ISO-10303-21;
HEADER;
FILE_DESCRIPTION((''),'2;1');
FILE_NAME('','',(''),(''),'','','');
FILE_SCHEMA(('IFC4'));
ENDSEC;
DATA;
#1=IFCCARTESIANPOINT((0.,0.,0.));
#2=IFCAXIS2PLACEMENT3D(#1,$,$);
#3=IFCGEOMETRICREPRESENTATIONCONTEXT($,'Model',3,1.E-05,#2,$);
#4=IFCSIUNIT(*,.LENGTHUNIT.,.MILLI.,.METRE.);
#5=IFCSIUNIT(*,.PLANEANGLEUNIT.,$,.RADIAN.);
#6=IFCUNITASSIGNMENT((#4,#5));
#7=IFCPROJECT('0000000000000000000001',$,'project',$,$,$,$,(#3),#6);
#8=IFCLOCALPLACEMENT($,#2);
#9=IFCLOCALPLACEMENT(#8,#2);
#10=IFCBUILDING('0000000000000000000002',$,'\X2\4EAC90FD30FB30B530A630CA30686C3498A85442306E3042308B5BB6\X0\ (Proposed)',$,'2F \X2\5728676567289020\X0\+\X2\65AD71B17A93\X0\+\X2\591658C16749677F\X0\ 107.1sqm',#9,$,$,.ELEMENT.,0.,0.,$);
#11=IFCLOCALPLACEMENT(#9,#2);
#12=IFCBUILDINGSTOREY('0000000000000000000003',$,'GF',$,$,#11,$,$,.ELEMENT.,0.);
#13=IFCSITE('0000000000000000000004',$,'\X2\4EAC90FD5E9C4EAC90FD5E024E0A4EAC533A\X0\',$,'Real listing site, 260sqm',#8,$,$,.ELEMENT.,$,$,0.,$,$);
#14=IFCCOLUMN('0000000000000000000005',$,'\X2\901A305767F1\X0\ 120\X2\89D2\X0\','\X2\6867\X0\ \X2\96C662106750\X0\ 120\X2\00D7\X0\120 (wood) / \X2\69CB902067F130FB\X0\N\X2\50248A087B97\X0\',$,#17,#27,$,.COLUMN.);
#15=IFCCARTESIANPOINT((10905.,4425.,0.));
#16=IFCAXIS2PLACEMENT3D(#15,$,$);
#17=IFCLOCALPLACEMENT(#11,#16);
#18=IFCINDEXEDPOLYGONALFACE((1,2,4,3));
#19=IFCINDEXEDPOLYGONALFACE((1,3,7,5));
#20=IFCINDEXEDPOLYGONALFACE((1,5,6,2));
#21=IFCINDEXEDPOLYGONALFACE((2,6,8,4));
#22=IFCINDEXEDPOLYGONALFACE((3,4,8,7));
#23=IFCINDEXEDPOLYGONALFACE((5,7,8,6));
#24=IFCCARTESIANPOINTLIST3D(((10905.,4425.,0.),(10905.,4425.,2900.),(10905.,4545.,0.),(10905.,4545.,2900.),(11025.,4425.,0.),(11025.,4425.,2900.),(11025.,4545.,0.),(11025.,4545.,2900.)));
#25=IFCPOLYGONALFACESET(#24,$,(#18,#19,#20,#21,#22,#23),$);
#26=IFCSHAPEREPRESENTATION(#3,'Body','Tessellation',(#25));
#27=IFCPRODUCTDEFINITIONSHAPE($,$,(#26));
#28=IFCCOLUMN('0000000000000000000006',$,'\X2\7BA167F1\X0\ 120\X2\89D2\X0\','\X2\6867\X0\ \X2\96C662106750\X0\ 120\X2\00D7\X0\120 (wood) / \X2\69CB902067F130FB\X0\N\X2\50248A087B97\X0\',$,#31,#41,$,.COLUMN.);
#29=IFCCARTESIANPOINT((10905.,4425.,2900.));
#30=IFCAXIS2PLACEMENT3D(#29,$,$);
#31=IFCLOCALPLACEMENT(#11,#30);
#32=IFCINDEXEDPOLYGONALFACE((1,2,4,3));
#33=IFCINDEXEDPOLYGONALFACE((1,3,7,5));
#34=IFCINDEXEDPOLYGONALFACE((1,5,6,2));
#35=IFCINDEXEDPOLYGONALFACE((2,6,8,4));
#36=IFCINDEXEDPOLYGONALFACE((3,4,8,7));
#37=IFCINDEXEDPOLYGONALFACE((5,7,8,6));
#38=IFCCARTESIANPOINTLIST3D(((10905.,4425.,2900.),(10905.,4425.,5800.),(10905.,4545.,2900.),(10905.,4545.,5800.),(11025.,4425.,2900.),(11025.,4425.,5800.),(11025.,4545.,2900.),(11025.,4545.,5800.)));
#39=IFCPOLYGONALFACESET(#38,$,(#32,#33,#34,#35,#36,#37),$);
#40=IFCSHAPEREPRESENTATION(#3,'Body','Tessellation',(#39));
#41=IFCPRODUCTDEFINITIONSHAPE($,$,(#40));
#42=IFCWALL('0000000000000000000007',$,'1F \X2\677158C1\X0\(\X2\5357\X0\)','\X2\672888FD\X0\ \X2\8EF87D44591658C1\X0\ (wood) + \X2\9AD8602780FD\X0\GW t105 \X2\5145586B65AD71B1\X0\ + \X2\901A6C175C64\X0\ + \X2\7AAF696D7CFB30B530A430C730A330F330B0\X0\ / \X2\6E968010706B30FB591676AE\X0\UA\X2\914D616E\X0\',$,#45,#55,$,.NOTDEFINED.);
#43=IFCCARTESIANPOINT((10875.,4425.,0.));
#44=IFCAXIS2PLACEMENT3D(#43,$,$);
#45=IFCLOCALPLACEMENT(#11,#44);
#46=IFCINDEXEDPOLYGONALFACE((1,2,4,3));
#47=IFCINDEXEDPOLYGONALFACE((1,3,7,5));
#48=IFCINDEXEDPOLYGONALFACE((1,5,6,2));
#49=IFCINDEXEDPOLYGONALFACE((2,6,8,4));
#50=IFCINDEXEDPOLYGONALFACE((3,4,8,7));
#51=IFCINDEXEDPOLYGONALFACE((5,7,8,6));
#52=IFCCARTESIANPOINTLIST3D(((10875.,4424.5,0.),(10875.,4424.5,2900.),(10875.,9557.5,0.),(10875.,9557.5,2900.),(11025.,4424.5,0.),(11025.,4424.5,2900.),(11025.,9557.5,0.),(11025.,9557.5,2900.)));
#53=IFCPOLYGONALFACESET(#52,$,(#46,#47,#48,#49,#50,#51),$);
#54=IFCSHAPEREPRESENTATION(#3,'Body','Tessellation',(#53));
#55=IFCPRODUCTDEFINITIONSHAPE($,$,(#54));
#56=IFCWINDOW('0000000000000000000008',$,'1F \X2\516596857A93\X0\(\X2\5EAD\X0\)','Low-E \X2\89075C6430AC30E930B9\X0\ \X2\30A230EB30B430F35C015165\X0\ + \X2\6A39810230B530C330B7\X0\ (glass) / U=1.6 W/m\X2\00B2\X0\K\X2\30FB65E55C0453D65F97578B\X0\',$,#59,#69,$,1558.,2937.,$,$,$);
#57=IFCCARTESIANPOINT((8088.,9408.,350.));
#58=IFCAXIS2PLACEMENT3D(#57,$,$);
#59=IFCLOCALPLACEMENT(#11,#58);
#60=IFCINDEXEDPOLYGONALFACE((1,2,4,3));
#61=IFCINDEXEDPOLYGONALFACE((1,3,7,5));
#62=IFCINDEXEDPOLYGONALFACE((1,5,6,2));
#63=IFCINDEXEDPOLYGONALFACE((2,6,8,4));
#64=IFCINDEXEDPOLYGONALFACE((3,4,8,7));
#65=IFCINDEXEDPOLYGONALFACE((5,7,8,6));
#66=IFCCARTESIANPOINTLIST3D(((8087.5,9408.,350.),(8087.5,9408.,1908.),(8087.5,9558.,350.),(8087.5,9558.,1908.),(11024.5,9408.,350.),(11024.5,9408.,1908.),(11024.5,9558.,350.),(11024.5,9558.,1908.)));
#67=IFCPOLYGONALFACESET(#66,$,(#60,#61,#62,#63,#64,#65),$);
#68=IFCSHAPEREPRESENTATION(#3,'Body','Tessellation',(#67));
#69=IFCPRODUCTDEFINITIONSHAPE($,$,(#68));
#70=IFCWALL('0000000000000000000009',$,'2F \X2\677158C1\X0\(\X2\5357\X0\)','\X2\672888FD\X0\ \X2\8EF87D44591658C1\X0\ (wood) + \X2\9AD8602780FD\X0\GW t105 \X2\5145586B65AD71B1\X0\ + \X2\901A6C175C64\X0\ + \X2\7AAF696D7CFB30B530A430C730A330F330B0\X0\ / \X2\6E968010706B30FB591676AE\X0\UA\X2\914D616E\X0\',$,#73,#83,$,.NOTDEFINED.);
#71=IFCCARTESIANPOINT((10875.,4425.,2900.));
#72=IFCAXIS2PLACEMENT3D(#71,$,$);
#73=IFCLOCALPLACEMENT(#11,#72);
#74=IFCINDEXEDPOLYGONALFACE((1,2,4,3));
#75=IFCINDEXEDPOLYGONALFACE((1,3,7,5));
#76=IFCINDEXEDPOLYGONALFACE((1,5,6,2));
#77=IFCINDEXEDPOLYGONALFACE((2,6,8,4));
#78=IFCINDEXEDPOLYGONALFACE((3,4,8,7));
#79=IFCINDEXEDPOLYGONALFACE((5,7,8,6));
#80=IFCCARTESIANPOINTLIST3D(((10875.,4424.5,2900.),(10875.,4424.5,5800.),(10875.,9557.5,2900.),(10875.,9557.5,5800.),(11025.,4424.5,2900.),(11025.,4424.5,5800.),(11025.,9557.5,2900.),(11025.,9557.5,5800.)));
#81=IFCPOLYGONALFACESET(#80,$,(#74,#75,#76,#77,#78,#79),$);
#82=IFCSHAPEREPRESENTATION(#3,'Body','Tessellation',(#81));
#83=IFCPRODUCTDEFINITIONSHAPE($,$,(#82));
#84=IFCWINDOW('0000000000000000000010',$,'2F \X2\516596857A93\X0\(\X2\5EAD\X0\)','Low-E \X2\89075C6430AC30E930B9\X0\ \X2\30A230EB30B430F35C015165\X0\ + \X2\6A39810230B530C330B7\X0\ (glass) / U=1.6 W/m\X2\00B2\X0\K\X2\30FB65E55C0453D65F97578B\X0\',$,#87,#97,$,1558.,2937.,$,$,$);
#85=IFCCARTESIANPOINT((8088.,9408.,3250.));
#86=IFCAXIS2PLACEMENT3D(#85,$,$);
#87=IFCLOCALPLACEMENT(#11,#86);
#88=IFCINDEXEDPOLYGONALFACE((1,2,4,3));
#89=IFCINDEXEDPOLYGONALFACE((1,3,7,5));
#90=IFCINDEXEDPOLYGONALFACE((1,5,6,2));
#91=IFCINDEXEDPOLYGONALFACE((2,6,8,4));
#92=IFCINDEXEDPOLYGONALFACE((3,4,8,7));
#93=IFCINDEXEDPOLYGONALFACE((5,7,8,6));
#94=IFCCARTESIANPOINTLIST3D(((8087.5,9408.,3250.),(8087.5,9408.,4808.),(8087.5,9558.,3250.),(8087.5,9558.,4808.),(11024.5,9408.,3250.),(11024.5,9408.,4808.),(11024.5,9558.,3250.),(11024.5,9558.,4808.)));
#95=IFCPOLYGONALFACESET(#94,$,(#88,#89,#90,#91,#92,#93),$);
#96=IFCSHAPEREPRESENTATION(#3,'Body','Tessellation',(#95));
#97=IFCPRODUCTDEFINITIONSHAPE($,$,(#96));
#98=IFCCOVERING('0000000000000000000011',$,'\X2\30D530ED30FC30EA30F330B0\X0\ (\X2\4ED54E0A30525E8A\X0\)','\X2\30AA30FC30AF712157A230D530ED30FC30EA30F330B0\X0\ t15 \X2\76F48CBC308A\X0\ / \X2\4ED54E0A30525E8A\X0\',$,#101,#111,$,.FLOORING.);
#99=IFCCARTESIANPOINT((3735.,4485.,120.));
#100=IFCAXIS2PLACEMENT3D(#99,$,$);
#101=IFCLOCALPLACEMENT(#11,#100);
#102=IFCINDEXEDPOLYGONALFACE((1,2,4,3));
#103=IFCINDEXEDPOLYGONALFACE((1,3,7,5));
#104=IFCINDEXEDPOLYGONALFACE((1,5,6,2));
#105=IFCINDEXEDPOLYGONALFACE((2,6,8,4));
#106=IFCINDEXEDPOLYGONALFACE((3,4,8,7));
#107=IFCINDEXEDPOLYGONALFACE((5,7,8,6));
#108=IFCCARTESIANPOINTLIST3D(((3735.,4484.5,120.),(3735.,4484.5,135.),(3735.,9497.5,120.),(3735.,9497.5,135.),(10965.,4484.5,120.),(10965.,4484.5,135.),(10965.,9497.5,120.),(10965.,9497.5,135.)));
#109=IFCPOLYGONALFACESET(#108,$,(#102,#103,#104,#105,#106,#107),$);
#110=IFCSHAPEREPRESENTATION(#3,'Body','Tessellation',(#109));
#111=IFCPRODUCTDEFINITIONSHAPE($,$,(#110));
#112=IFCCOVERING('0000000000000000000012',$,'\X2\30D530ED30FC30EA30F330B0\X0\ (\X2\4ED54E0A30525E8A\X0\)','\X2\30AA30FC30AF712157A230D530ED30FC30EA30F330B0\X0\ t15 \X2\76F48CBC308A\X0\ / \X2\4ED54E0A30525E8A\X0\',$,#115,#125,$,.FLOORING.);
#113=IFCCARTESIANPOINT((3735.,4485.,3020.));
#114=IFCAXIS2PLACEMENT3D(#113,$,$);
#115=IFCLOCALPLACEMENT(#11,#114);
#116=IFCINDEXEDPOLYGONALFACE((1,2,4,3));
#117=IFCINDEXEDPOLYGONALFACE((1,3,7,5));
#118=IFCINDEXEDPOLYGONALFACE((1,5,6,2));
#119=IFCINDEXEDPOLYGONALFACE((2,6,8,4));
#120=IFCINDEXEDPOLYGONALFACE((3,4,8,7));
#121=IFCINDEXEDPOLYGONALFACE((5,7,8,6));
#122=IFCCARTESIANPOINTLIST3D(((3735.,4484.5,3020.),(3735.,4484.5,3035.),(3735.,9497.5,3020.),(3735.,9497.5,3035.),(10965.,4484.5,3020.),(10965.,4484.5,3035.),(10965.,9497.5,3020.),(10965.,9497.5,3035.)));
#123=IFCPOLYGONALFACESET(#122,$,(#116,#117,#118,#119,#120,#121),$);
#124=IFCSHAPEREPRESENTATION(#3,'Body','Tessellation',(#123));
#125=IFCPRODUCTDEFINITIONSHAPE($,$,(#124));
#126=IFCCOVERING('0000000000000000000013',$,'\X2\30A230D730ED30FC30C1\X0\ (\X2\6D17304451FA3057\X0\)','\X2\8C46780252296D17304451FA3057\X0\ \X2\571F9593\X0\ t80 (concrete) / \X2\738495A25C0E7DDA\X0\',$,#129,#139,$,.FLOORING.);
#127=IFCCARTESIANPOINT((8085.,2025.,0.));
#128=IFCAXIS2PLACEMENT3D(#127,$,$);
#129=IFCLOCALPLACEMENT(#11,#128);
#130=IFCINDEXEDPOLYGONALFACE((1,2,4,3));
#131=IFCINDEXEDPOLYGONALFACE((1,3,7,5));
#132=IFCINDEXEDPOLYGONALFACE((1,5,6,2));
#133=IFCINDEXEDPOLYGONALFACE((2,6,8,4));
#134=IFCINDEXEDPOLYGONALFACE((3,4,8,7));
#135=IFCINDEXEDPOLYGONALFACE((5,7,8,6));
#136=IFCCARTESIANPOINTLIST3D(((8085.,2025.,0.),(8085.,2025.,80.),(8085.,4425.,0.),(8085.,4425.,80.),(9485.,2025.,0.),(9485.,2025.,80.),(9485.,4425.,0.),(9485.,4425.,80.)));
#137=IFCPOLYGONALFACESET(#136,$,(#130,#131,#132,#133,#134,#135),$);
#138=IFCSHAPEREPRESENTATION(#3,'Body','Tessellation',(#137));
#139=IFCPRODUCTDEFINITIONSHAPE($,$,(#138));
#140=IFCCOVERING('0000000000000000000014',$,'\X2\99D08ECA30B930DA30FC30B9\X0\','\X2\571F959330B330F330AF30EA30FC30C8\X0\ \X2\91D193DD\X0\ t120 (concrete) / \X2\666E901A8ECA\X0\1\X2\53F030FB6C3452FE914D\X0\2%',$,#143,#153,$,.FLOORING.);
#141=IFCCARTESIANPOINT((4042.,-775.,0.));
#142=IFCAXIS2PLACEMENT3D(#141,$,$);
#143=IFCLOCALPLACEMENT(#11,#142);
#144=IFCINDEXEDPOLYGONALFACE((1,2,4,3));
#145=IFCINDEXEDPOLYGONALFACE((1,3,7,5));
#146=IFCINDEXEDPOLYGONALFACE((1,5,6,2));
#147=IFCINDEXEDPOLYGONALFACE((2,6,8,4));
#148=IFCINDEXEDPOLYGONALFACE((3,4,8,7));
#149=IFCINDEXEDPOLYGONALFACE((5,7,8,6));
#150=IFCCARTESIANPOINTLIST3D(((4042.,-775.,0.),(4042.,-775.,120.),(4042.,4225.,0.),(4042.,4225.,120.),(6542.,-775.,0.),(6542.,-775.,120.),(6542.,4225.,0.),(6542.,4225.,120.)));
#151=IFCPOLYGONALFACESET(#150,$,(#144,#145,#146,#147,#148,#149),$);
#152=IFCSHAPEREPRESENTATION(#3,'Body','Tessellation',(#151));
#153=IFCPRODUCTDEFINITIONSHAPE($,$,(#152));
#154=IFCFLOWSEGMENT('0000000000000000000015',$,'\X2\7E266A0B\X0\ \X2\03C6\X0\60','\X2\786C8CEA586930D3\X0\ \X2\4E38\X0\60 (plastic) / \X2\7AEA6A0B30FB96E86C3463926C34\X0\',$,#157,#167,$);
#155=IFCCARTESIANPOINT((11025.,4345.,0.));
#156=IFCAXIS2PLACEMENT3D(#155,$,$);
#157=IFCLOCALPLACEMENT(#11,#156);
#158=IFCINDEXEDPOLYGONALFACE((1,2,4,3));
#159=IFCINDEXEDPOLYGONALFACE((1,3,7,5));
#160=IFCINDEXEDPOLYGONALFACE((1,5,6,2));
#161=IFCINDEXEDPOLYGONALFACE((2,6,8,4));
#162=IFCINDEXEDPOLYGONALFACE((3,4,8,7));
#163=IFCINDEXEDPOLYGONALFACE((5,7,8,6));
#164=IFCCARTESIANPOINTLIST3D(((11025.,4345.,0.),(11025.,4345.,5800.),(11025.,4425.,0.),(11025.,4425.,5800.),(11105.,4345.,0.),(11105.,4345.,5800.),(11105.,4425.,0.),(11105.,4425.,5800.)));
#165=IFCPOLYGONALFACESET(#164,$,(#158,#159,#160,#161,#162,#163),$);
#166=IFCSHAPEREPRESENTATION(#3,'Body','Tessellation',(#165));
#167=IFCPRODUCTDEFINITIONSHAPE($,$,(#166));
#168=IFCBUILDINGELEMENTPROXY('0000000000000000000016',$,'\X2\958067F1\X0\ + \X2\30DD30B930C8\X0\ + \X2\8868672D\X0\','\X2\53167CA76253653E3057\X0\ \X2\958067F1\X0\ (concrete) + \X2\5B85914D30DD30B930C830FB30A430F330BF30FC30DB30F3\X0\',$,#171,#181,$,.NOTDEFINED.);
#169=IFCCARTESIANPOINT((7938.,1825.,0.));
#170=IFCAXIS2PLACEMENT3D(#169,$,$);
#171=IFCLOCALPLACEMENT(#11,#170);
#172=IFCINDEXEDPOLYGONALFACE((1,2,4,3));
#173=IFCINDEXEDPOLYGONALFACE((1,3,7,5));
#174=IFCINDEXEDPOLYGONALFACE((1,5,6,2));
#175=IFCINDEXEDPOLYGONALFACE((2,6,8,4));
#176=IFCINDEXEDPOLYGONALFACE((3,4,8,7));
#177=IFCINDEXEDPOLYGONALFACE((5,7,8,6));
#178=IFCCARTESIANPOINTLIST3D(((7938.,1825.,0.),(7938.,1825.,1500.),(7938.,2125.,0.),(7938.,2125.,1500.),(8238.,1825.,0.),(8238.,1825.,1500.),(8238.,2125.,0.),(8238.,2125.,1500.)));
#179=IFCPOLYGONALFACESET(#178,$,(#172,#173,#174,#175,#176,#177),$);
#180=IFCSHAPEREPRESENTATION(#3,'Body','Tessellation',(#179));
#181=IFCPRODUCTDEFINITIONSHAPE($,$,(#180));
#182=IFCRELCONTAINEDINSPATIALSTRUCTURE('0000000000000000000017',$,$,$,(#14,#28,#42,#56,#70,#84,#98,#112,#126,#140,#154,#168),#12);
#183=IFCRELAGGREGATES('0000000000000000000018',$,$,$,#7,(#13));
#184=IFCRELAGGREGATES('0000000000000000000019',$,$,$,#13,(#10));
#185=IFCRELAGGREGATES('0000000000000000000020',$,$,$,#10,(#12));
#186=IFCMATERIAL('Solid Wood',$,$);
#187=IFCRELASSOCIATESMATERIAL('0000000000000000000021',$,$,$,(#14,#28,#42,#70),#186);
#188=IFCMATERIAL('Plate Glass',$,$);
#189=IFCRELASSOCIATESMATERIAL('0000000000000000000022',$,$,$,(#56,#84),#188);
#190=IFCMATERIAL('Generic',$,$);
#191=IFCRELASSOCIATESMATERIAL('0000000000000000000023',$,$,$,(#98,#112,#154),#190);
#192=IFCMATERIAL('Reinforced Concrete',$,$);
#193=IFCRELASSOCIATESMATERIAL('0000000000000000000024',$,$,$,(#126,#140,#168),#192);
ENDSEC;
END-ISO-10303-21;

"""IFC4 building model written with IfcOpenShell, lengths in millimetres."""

from ifc_helpers import new_model, si_unit, frame, frame_2d, origin, place, context, project, spatial, rectangle, extrude, material, element, fill, save


model = new_model("IFC4")

# Units and contexts
model_context = context("Model", 3, precision=1e-05, world=origin())
ifc_project = project(units=[si_unit("LENGTHUNIT", "METRE", prefix="MILLI"), si_unit("PLANEANGLEUNIT", "RADIAN")], contexts=[model_context])

# Site, building, storey
site_placement = place(None, origin())
site = spatial("IfcSite", under=ifc_project, at=site_placement, Name="京都府京都市上京区", ObjectType="Real listing site, 260sqm", CompositionType="ELEMENT", RefElevation=0.0)
building_placement = place(site_placement, origin())
building = spatial("IfcBuilding", under=site, at=building_placement, Name="京都・サウナと水風呂のある家 (Proposed)", ObjectType="2F 在来木造+断熱窓+外壁杉板 107.1sqm", CompositionType="ELEMENT", ElevationOfRefHeight=0.0, ElevationOfTerrain=0.0)
storey_placement = place(building_placement, origin())
storey = spatial("IfcBuildingStorey", under=building, at=storey_placement, Name="GF", CompositionType="ELEMENT", Elevation=0.0)

# Columns
ifc_material_1 = material(Name="Solid Wood")
column_1_placement = place(storey_placement, frame((10905.0, 4425.0, 0.0)))
element("IfcColumn", 1, at=column_1_placement, inside=storey, material=ifc_material_1, Name="通し柱 120角", Description="桧 集成材 120×120 (wood) / 構造柱・N値計算", PredefinedType="COLUMN", context=model_context, shape_type="SweptSolid", body=[
    extrude(rectangle(XDim=120.0, YDim=120.0, at=frame_2d((60.0, 60.0))), frame((10905.0, 4425.0, 0.0)), (0.0, 0.0, 1.0), 2900.0),
])
column_2_placement = place(storey_placement, frame((10905.0, 4425.0, 2900.0)))
element("IfcColumn", 2, at=column_2_placement, inside=storey, material=ifc_material_1, Name="管柱 120角", Description="桧 集成材 120×120 (wood) / 構造柱・N値計算", PredefinedType="COLUMN", context=model_context, shape_type="SweptSolid", body=[
    extrude(rectangle(XDim=120.0, YDim=120.0, at=frame_2d((60.0, 60.0))), frame((10905.0, 4425.0, 2900.0)), (0.0, 0.0, 1.0), 2900.0),
])

# Wall, opening, window
wall_1_placement = place(storey_placement, frame((10875.0, 4425.0, 0.0)))
wall_1 = element("IfcWall", 3, at=wall_1_placement, inside=storey, material=ifc_material_1, Name="1F 東壁(南)", Description="木製 軸組外壁 (wood) + 高性能GW t105 充填断熱 + 通気層 + 窯業系サイディング / 準耐火・外皮UA配慮", PredefinedType="NOTDEFINED", context=model_context, shape_type="SweptSolid", body=[
    extrude(rectangle(XDim=150.0, YDim=5133.0, at=frame_2d((75.0, 2566.0))), frame((10875.0, 4425.0, 0.0)), (0.0, 0.0, 1.0), 2900.0),
])
opening_1_placement = place(storey_placement, frame((8088.0, 9408.0, 350.0)))
opening_1 = element("IfcOpeningElement", 4, at=opening_1_placement, cuts=wall_1, PredefinedType="NOTDEFINED", context=model_context, shape_type="SweptSolid", body=[
    extrude(rectangle(XDim=2937.0, YDim=150.0, at=frame_2d((1468.0, 75.0))), frame((8088.0, 9408.0, 350.0)), (0.0, 0.0, 1.0), 1558.0),
])
ifc_material_2 = material(Name="Plate Glass")
window_1_placement = place(storey_placement, frame((8088.0, 9408.0, 350.0)))
window_1 = element("IfcWindow", 5, at=window_1_placement, inside=storey, material=ifc_material_2, Name="1F 入隅窓(庭)", Description="Low-E 複層ガラス アルゴン封入 + 樹脂サッシ (glass) / U=1.6 W/m²K・日射取得型", OverallHeight=1558.0, OverallWidth=2937.0, context=model_context, shape_type="SweptSolid", body=[
    extrude(rectangle(XDim=2937.0, YDim=150.0, at=frame_2d((1468.0, 75.0))), frame((8088.0, 9408.0, 350.0)), (0.0, 0.0, 1.0), 1558.0),
])
fill(opening_1, window_1)

# Wall, opening, window
wall_2_placement = place(storey_placement, frame((10875.0, 4425.0, 2900.0)))
wall_2 = element("IfcWall", 6, at=wall_2_placement, inside=storey, material=ifc_material_1, Name="2F 東壁(南)", Description="木製 軸組外壁 (wood) + 高性能GW t105 充填断熱 + 通気層 + 窯業系サイディング / 準耐火・外皮UA配慮", PredefinedType="NOTDEFINED", context=model_context, shape_type="SweptSolid", body=[
    extrude(rectangle(XDim=150.0, YDim=5133.0, at=frame_2d((75.0, 2566.0))), frame((10875.0, 4425.0, 2900.0)), (0.0, 0.0, 1.0), 2900.0),
])
opening_2_placement = place(storey_placement, frame((8088.0, 9408.0, 3250.0)))
opening_2 = element("IfcOpeningElement", 7, at=opening_2_placement, cuts=wall_2, PredefinedType="NOTDEFINED", context=model_context, shape_type="SweptSolid", body=[
    extrude(rectangle(XDim=2937.0, YDim=150.0, at=frame_2d((1468.0, 75.0))), frame((8088.0, 9408.0, 3250.0)), (0.0, 0.0, 1.0), 1558.0),
])
window_2_placement = place(storey_placement, frame((8088.0, 9408.0, 3250.0)))
window_2 = element("IfcWindow", 8, at=window_2_placement, inside=storey, material=ifc_material_2, Name="2F 入隅窓(庭)", Description="Low-E 複層ガラス アルゴン封入 + 樹脂サッシ (glass) / U=1.6 W/m²K・日射取得型", OverallHeight=1558.0, OverallWidth=2937.0, context=model_context, shape_type="SweptSolid", body=[
    extrude(rectangle(XDim=2937.0, YDim=150.0, at=frame_2d((1468.0, 75.0))), frame((8088.0, 9408.0, 3250.0)), (0.0, 0.0, 1.0), 1558.0),
])
fill(opening_2, window_2)

# Coverings
ifc_material_3 = material(Name="Generic")
covering_1_placement = place(storey_placement, frame((3735.0, 4485.0, 120.0)))
element("IfcCovering", 9, at=covering_1_placement, inside=storey, material=ifc_material_3, Name="フローリング (仕上げ床)", Description="オーク無垢フローリング t15 直貼り / 仕上げ床", PredefinedType="FLOORING", context=model_context, shape_type="SweptSolid", body=[
    extrude(rectangle(XDim=7230.0, YDim=5013.0, at=frame_2d((3615.0, 2506.0))), frame((3735.0, 4485.0, 120.0)), (0.0, 0.0, 1.0), 15.0),
])
covering_2_placement = place(storey_placement, frame((3735.0, 4485.0, 3020.0)))
element("IfcCovering", 10, at=covering_2_placement, inside=storey, material=ifc_material_3, Name="フローリング (仕上げ床)", Description="オーク無垢フローリング t15 直貼り / 仕上げ床", PredefinedType="FLOORING", context=model_context, shape_type="SweptSolid", body=[
    extrude(rectangle(XDim=7230.0, YDim=5013.0, at=frame_2d((3615.0, 2506.0))), frame((3735.0, 4485.0, 3020.0)), (0.0, 0.0, 1.0), 15.0),
])
ifc_material_4 = material(Name="Reinforced Concrete")
covering_3_placement = place(storey_placement, frame((8085.0, 2025.0, 0.0)))
element("IfcCovering", 11, at=covering_3_placement, inside=storey, material=ifc_material_4, Name="アプローチ (洗い出し)", Description="豆砂利洗い出し 土間 t80 (concrete) / 玄関導線", PredefinedType="FLOORING", context=model_context, shape_type="SweptSolid", body=[
    extrude(rectangle(XDim=1400.0, YDim=2400.0, at=frame_2d((700.0, 1200.0))), frame((8085.0, 2025.0, 0.0)), (0.0, 0.0, 1.0), 80.0),
])
covering_4_placement = place(storey_placement, frame((4042.0, -775.0, 0.0)))
element("IfcCovering", 12, at=covering_4_placement, inside=storey, material=ifc_material_4, Name="駐車スペース", Description="土間コンクリート 金鏝 t120 (concrete) / 普通車1台・水勾配2%", PredefinedType="FLOORING", context=model_context, shape_type="SweptSolid", body=[
    extrude(rectangle(XDim=2500.0, YDim=5000.0, at=frame_2d((1250.0, 2500.0))), frame((4042.0, -775.0, 0.0)), (0.0, 0.0, 1.0), 120.0),
])

# Flow segment
flow_segment_placement = place(storey_placement, frame((11025.0, 4345.0, 0.0)))
element("IfcFlowSegment", 13, at=flow_segment_placement, inside=storey, material=ifc_material_3, Name="縦樋 φ60", Description="硬質塩ビ 丸60 (plastic) / 竪樋・雨水排水", context=model_context, shape_type="SweptSolid", body=[
    extrude(rectangle(XDim=80.0, YDim=80.0, at=frame_2d((40.0, 40.0))), frame((11025.0, 4345.0, 0.0)), (0.0, 0.0, 1.0), 5800.0),
])

# Building element proxy
proxy_placement = place(storey_placement, frame((7938.0, 1825.0, 0.0)))
element("IfcBuildingElementProxy", 14, at=proxy_placement, inside=storey, material=ifc_material_4, Name="門柱 + ポスト + 表札", Description="化粧打放し 門柱 (concrete) + 宅配ポスト・インターホン", PredefinedType="NOTDEFINED", context=model_context, shape_type="SweptSolid", body=[
    extrude(rectangle(XDim=300.0, YDim=300.0, at=frame_2d((150.0, 150.0))), frame((7938.0, 1825.0, 0.0)), (0.0, 0.0, 1.0), 1500.0),
])

save(model, "model.ifc")
